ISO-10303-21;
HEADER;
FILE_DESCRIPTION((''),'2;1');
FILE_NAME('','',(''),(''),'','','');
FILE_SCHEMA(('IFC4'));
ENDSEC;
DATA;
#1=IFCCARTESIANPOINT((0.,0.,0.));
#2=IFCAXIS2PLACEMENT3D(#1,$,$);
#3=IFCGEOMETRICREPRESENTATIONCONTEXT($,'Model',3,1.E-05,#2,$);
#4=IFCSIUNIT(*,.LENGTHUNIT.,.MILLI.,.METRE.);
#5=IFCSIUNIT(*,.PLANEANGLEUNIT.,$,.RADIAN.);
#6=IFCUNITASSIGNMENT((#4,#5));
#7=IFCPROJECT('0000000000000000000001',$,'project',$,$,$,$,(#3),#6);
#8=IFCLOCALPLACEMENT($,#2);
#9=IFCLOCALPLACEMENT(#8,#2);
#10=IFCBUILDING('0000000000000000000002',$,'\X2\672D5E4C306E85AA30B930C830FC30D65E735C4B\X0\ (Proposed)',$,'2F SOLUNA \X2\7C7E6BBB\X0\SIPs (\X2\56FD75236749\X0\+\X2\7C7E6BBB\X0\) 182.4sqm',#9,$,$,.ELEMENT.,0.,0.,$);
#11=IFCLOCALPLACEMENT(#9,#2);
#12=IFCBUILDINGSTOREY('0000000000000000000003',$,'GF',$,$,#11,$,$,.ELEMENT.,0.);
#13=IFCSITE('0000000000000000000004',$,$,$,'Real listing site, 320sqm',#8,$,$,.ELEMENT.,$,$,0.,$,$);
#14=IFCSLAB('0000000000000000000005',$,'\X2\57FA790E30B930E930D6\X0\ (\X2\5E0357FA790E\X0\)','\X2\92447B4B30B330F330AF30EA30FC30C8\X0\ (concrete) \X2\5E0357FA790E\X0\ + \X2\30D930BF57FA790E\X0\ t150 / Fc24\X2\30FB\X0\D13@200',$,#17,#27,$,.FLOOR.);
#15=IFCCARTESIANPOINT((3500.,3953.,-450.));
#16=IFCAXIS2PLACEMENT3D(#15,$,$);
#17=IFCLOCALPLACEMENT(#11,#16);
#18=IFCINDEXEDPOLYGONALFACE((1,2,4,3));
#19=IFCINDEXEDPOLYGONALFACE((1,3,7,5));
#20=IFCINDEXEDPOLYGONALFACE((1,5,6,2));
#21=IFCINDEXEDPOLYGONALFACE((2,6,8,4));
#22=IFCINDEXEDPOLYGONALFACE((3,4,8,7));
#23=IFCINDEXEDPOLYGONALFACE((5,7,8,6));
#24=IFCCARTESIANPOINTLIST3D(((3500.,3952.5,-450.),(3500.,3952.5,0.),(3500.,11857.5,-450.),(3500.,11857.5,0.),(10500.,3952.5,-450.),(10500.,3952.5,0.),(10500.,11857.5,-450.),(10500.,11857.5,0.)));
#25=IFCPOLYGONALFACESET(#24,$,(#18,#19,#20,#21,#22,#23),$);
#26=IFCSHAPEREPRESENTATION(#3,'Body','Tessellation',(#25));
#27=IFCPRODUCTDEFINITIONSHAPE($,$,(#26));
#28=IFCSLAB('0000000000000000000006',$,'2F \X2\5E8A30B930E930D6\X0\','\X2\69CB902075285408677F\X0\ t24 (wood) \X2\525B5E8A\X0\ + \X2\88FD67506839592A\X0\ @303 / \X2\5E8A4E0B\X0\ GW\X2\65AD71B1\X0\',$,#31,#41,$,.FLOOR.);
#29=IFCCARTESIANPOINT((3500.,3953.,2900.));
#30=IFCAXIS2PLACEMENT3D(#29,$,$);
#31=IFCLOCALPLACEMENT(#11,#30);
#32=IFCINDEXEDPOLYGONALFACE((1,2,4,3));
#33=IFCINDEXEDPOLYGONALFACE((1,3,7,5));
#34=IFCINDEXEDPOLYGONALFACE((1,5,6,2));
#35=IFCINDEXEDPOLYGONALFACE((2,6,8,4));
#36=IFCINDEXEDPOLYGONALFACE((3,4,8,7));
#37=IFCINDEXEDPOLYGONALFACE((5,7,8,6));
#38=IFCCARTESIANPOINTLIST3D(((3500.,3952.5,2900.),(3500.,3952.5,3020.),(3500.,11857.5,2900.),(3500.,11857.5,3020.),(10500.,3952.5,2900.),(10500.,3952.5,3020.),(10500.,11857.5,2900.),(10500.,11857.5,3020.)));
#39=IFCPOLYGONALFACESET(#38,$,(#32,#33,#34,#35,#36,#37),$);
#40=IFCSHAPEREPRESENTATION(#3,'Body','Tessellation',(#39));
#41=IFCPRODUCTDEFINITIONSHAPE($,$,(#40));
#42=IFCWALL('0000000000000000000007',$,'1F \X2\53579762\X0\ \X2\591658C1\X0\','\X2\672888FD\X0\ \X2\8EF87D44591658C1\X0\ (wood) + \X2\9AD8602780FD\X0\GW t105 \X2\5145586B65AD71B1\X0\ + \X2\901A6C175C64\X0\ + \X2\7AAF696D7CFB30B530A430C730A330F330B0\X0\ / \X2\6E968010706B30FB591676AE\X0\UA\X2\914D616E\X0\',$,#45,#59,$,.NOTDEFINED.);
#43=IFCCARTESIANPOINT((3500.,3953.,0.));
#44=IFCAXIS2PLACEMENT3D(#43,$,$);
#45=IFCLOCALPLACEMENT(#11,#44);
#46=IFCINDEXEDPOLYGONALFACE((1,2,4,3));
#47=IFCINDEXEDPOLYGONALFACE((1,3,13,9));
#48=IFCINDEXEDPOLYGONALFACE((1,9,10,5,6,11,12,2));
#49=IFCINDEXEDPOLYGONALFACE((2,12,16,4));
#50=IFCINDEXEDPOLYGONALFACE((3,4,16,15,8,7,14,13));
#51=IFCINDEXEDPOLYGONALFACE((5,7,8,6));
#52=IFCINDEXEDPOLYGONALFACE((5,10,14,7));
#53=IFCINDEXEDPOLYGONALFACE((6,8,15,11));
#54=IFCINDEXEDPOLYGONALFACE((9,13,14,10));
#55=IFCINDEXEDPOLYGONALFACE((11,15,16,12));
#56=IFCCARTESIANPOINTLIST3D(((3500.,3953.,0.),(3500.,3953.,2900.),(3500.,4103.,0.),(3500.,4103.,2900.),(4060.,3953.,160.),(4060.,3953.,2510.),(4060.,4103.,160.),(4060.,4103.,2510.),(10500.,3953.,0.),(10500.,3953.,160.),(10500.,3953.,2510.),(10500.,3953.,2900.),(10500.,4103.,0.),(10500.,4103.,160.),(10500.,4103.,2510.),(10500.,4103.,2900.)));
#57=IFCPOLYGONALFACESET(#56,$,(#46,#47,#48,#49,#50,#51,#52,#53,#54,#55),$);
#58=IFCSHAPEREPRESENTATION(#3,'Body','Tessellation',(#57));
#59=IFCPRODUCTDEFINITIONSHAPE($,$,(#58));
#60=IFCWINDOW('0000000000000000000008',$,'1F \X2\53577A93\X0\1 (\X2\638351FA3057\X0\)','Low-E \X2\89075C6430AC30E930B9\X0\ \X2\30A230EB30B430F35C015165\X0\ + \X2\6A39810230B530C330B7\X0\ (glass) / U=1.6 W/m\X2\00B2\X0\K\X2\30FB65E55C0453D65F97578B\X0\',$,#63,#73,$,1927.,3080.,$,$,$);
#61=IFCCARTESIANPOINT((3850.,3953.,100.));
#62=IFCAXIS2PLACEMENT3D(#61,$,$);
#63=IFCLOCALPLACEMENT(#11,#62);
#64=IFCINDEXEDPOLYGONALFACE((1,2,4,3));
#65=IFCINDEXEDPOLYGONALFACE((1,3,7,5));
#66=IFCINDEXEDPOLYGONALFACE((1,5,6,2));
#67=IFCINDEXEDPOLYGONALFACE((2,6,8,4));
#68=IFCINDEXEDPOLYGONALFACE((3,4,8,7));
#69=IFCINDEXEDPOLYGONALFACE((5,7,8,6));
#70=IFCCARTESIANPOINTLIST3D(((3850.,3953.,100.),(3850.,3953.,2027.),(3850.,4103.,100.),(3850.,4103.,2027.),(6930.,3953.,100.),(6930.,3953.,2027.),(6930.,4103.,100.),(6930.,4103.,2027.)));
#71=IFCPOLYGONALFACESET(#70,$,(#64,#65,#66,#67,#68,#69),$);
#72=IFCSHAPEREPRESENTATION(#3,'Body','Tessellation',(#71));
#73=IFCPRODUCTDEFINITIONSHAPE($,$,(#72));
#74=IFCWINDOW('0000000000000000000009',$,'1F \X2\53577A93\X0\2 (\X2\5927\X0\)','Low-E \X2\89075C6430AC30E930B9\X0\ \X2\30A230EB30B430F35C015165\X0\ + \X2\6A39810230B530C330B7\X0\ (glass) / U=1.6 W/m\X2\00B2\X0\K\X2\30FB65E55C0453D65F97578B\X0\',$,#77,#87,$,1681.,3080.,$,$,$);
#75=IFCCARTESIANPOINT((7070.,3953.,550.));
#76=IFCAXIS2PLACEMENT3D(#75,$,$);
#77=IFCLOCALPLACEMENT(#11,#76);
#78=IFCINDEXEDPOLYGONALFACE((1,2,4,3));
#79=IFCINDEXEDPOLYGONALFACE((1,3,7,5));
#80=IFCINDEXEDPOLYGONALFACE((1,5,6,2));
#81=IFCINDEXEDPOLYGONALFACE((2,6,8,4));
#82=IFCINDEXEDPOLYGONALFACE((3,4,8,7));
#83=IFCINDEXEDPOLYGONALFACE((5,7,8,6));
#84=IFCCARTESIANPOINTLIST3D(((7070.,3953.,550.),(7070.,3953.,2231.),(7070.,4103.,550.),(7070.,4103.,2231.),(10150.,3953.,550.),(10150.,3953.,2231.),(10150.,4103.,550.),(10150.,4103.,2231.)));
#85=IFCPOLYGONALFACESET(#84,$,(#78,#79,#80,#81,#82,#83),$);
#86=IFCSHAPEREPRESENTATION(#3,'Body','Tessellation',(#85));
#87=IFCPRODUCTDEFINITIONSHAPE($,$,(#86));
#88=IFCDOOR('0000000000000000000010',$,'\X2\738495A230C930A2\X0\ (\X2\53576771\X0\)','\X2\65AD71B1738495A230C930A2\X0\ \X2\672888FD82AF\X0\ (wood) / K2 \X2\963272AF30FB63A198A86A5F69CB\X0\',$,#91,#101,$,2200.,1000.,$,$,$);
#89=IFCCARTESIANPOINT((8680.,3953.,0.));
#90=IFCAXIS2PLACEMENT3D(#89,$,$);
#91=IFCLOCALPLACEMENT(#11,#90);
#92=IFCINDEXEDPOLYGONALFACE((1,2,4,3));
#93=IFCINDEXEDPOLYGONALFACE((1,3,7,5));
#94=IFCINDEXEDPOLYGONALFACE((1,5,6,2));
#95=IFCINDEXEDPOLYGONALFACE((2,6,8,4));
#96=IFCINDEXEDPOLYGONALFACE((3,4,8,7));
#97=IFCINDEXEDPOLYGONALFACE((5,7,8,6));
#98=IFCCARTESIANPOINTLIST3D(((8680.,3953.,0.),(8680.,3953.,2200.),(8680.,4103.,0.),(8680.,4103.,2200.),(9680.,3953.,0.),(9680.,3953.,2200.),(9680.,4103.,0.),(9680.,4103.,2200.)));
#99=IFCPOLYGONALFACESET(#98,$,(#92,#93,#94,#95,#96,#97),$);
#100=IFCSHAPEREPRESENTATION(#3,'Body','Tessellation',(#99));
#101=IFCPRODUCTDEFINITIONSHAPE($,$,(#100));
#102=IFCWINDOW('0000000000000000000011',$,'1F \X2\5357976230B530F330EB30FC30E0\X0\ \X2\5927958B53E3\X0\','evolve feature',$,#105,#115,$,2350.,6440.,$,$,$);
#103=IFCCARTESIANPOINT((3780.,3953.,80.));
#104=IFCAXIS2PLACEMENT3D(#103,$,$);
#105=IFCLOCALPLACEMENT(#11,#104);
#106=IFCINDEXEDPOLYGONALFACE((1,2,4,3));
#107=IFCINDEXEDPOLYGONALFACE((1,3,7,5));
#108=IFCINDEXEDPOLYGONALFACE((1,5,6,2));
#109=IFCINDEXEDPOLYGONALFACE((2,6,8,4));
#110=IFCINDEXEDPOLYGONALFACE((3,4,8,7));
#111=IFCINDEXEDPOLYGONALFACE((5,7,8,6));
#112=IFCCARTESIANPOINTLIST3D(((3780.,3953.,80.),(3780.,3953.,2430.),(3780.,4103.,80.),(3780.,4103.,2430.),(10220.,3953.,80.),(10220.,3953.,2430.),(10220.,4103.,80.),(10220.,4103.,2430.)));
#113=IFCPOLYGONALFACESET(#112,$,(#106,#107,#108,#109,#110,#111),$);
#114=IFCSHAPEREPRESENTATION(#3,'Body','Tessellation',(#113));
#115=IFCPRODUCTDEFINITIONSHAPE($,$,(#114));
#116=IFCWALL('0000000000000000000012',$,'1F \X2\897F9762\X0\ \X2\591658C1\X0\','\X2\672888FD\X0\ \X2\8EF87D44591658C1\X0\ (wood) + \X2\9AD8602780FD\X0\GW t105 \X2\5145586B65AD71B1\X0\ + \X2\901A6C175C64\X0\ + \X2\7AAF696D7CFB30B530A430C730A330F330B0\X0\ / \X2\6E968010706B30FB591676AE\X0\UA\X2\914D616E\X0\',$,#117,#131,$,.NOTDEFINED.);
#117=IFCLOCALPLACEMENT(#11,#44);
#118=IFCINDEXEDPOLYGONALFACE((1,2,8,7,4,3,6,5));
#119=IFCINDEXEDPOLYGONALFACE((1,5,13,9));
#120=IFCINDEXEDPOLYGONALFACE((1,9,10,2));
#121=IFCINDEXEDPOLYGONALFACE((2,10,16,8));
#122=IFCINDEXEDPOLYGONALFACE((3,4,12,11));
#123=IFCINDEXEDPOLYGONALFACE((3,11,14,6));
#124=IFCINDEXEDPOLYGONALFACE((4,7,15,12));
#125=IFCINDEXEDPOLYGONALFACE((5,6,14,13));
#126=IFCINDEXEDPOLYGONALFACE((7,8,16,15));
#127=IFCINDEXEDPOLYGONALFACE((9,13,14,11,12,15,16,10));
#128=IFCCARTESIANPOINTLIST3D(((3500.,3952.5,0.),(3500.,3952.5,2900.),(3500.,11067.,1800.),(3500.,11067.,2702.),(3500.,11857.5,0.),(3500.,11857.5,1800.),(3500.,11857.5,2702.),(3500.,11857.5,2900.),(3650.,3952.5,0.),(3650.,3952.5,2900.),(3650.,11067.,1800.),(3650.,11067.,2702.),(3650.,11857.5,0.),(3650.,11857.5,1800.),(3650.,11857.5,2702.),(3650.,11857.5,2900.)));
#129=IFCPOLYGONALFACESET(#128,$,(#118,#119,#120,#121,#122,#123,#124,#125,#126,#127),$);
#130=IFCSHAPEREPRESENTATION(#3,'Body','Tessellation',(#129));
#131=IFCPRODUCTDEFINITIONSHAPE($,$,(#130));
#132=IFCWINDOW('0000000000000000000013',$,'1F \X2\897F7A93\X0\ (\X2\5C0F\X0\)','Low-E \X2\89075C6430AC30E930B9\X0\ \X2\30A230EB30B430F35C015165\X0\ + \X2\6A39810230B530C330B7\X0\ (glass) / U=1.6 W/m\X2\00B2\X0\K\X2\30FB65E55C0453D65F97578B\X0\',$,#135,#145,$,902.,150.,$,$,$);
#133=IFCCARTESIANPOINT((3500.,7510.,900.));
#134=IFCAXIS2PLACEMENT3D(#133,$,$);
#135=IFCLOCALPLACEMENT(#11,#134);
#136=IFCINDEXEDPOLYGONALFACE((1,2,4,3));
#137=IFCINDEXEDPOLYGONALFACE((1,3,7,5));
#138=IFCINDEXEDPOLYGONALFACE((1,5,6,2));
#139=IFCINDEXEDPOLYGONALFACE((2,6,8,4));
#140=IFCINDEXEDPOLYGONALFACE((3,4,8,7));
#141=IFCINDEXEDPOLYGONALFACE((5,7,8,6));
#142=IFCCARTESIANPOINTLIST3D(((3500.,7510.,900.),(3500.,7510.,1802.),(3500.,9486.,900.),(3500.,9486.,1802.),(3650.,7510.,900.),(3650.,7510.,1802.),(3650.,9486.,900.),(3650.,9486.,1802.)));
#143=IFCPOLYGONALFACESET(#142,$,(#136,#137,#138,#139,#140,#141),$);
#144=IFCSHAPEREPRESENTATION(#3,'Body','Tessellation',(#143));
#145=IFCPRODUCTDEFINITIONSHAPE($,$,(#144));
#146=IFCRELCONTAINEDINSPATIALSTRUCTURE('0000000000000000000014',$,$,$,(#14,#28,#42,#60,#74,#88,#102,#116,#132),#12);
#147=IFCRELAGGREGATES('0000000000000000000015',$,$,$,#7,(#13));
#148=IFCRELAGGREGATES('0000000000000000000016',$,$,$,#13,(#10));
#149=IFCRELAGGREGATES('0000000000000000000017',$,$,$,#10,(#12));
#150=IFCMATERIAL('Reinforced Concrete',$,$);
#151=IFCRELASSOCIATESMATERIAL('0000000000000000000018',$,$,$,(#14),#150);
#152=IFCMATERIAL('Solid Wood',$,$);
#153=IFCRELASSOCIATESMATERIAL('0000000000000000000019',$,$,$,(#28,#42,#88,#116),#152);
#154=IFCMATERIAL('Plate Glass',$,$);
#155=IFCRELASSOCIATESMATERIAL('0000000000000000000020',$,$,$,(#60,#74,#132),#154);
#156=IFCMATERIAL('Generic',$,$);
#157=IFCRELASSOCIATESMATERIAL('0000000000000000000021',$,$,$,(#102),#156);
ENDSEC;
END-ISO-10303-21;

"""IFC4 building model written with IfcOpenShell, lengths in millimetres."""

from ifc_helpers import new_model, si_unit, frame, frame_2d, origin, place, context, project, spatial, rectangle, extrude, material, element, fill, save


model = new_model("IFC4")

# Units and contexts
model_context = context("Model", 3, precision=1e-05, world=origin())
ifc_project = project(units=[si_unit("LENGTHUNIT", "METRE", prefix="MILLI"), si_unit("PLANEANGLEUNIT", "RADIAN")], contexts=[model_context])

# Site, building, storey
site_placement = place(None, origin())
site = spatial("IfcSite", under=ifc_project, at=site_placement, ObjectType="Real listing site, 320sqm", CompositionType="ELEMENT", RefElevation=0.0)
building_placement = place(site_placement, origin())
building = spatial("IfcBuilding", under=site, at=building_placement, Name="札幌の薪ストーブ平屋 (Proposed)", ObjectType="2F SOLUNA 籾殻SIPs (国産杉+籾殻) 182.4sqm", CompositionType="ELEMENT", ElevationOfRefHeight=0.0, ElevationOfTerrain=0.0)
storey_placement = place(building_placement, origin())
storey = spatial("IfcBuildingStorey", under=building, at=storey_placement, Name="GF", CompositionType="ELEMENT", Elevation=0.0)

# Slabs
ifc_material_1 = material(Name="Reinforced Concrete")
slab_1_placement = place(storey_placement, frame((3500.0, 3953.0, -450.0)))
element("IfcSlab", 1, at=slab_1_placement, inside=storey, material=ifc_material_1, Name="基礎スラブ (布基礎)", Description="鉄筋コンクリート (concrete) 布基礎 + ベタ基礎 t150 / Fc24・D13@200", PredefinedType="FLOOR", context=model_context, shape_type="SweptSolid", body=[
    extrude(rectangle(XDim=7000.0, YDim=7905.0, at=frame_2d((3500.0, 3952.0))), frame((3500.0, 3953.0, -450.0)), (0.0, 0.0, 1.0), 450.0),
])
ifc_material_2 = material(Name="Solid Wood")
slab_2_placement = place(storey_placement, frame((3500.0, 3953.0, 2900.0)))
element("IfcSlab", 2, at=slab_2_placement, inside=storey, material=ifc_material_2, Name="2F 床スラブ", Description="構造用合板 t24 (wood) 剛床 + 製材根太 @303 / 床下 GW断熱", PredefinedType="FLOOR", context=model_context, shape_type="SweptSolid", body=[
    extrude(rectangle(XDim=7000.0, YDim=7905.0, at=frame_2d((3500.0, 3952.0))), frame((3500.0, 3953.0, 2900.0)), (0.0, 0.0, 1.0), 120.0),
])
ifc_material_3 = material(Name="Generic")

# Wall, openings, windows, door
wall_1_placement = place(storey_placement, frame((3500.0, 3953.0, 0.0)))
wall_1 = element("IfcWall", 3, at=wall_1_placement, inside=storey, material=ifc_material_2, Name="1F 南面 外壁", Description="木製 軸組外壁 (wood) + 高性能GW t105 充填断熱 + 通気層 + 窯業系サイディング / 準耐火・外皮UA配慮", PredefinedType="NOTDEFINED", context=model_context, shape_type="SweptSolid", body=[
    extrude(rectangle(XDim=7000.0, YDim=150.0, at=frame_2d((3500.0, 75.0))), frame((3500.0, 3953.0, 0.0)), (0.0, 0.0, 1.0), 2900.0),
])
opening_1_placement = place(storey_placement, frame((3850.0, 3953.0, 100.0)))
opening_1 = element("IfcOpeningElement", 4, at=opening_1_placement, cuts=wall_1, PredefinedType="NOTDEFINED", context=model_context, shape_type="SweptSolid", body=[
    extrude(rectangle(XDim=3080.0, YDim=150.0, at=frame_2d((1540.0, 75.0))), frame((3850.0, 3953.0, 100.0)), (0.0, 0.0, 1.0), 1927.0),
])
opening_2_placement = place(storey_placement, frame((7070.0, 3953.0, 550.0)))
opening_2 = element("IfcOpeningElement", 5, at=opening_2_placement, cuts=wall_1, PredefinedType="NOTDEFINED", context=model_context, shape_type="SweptSolid", body=[
    extrude(rectangle(XDim=3080.0, YDim=150.0, at=frame_2d((1540.0, 75.0))), frame((7070.0, 3953.0, 550.0)), (0.0, 0.0, 1.0), 1681.0),
])
opening_3_placement = place(storey_placement, frame((8680.0, 3953.0, 0.0)))
opening_3 = element("IfcOpeningElement", 6, at=opening_3_placement, cuts=wall_1, PredefinedType="NOTDEFINED", context=model_context, shape_type="SweptSolid", body=[
    extrude(rectangle(XDim=1000.0, YDim=150.0, at=frame_2d((500.0, 75.0))), frame((8680.0, 3953.0, 0.0)), (0.0, 0.0, 1.0), 2200.0),
])
opening_4_placement = place(storey_placement, frame((3780.0, 3953.0, 80.0)))
opening_4 = element("IfcOpeningElement", 7, at=opening_4_placement, cuts=wall_1, PredefinedType="NOTDEFINED", context=model_context, shape_type="SweptSolid", body=[
    extrude(rectangle(XDim=6440.0, YDim=150.0, at=frame_2d((3220.0, 75.0))), frame((3780.0, 3953.0, 80.0)), (0.0, 0.0, 1.0), 2350.0),
])
ifc_material_4 = material(Name="Plate Glass")
window_1_placement = place(storey_placement, frame((3850.0, 3953.0, 100.0)))
window_1 = element("IfcWindow", 8, at=window_1_placement, inside=storey, material=ifc_material_4, Name="1F 南窓1 (掃出し)", Description="Low-E 複層ガラス アルゴン封入 + 樹脂サッシ (glass) / U=1.6 W/m²K・日射取得型", OverallHeight=1927.0, OverallWidth=3080.0, context=model_context, shape_type="SweptSolid", body=[
    extrude(rectangle(XDim=3080.0, YDim=150.0, at=frame_2d((1540.0, 75.0))), frame((3850.0, 3953.0, 100.0)), (0.0, 0.0, 1.0), 1927.0),
])
fill(opening_1, window_1)
window_2_placement = place(storey_placement, frame((7070.0, 3953.0, 550.0)))
window_2 = element("IfcWindow", 9, at=window_2_placement, inside=storey, material=ifc_material_4, Name="1F 南窓2 (大)", Description="Low-E 複層ガラス アルゴン封入 + 樹脂サッシ (glass) / U=1.6 W/m²K・日射取得型", OverallHeight=1681.0, OverallWidth=3080.0, context=model_context, shape_type="SweptSolid", body=[
    extrude(rectangle(XDim=3080.0, YDim=150.0, at=frame_2d((1540.0, 75.0))), frame((7070.0, 3953.0, 550.0)), (0.0, 0.0, 1.0), 1681.0),
])
fill(opening_2, window_2)
door_placement = place(storey_placement, frame((8680.0, 3953.0, 0.0)))
door = element("IfcDoor", 10, at=door_placement, inside=storey, material=ifc_material_2, Name="玄関ドア (南東)", Description="断熱玄関ドア 木製芯 (wood) / K2 防犯・採風機構", OverallHeight=2200.0, OverallWidth=1000.0, context=model_context, shape_type="SweptSolid", body=[
    extrude(rectangle(XDim=1000.0, YDim=150.0, at=frame_2d((500.0, 75.0))), frame((8680.0, 3953.0, 0.0)), (0.0, 0.0, 1.0), 2200.0),
])
fill(opening_3, door)
window_3_placement = place(storey_placement, frame((3780.0, 3953.0, 80.0)))
window_3 = element("IfcWindow", 11, at=window_3_placement, inside=storey, material=ifc_material_3, Name="1F 南面サンルーム 大開口", Description="evolve feature", OverallHeight=2350.0, OverallWidth=6440.0, context=model_context, shape_type="SweptSolid", body=[
    extrude(rectangle(XDim=6440.0, YDim=150.0, at=frame_2d((3220.0, 75.0))), frame((3780.0, 3953.0, 80.0)), (0.0, 0.0, 1.0), 2350.0),
])
fill(opening_4, window_3)

# Wall, opening, window
wall_2_placement = place(storey_placement, frame((3500.0, 3953.0, 0.0)))
wall_2 = element("IfcWall", 12, at=wall_2_placement, inside=storey, material=ifc_material_2, Name="1F 西面 外壁", Description="木製 軸組外壁 (wood) + 高性能GW t105 充填断熱 + 通気層 + 窯業系サイディング / 準耐火・外皮UA配慮", PredefinedType="NOTDEFINED", context=model_context, shape_type="SweptSolid", body=[
    extrude(rectangle(XDim=150.0, YDim=7905.0, at=frame_2d((75.0, 3952.0))), frame((3500.0, 3953.0, 0.0)), (0.0, 0.0, 1.0), 2900.0),
])
opening_5_placement = place(storey_placement, frame((3500.0, 7510.0, 900.0)))
opening_5 = element("IfcOpeningElement", 13, at=opening_5_placement, cuts=wall_2, PredefinedType="NOTDEFINED", context=model_context, shape_type="SweptSolid", body=[
    extrude(rectangle(XDim=150.0, YDim=1976.0, at=frame_2d((75.0, 988.0))), frame((3500.0, 7510.0, 900.0)), (0.0, 0.0, 1.0), 902.0),
])
window_4_placement = place(storey_placement, frame((3500.0, 7510.0, 900.0)))
window_4 = element("IfcWindow", 14, at=window_4_placement, inside=storey, material=ifc_material_4, Name="1F 西窓 (小)", Description="Low-E 複層ガラス アルゴン封入 + 樹脂サッシ (glass) / U=1.6 W/m²K・日射取得型", OverallHeight=902.0, OverallWidth=150.0, context=model_context, shape_type="SweptSolid", body=[
    extrude(rectangle(XDim=150.0, YDim=1976.0, at=frame_2d((75.0, 988.0))), frame((3500.0, 7510.0, 900.0)), (0.0, 0.0, 1.0), 902.0),
])
fill(opening_5, window_4)

save(model, "model.ifc")
